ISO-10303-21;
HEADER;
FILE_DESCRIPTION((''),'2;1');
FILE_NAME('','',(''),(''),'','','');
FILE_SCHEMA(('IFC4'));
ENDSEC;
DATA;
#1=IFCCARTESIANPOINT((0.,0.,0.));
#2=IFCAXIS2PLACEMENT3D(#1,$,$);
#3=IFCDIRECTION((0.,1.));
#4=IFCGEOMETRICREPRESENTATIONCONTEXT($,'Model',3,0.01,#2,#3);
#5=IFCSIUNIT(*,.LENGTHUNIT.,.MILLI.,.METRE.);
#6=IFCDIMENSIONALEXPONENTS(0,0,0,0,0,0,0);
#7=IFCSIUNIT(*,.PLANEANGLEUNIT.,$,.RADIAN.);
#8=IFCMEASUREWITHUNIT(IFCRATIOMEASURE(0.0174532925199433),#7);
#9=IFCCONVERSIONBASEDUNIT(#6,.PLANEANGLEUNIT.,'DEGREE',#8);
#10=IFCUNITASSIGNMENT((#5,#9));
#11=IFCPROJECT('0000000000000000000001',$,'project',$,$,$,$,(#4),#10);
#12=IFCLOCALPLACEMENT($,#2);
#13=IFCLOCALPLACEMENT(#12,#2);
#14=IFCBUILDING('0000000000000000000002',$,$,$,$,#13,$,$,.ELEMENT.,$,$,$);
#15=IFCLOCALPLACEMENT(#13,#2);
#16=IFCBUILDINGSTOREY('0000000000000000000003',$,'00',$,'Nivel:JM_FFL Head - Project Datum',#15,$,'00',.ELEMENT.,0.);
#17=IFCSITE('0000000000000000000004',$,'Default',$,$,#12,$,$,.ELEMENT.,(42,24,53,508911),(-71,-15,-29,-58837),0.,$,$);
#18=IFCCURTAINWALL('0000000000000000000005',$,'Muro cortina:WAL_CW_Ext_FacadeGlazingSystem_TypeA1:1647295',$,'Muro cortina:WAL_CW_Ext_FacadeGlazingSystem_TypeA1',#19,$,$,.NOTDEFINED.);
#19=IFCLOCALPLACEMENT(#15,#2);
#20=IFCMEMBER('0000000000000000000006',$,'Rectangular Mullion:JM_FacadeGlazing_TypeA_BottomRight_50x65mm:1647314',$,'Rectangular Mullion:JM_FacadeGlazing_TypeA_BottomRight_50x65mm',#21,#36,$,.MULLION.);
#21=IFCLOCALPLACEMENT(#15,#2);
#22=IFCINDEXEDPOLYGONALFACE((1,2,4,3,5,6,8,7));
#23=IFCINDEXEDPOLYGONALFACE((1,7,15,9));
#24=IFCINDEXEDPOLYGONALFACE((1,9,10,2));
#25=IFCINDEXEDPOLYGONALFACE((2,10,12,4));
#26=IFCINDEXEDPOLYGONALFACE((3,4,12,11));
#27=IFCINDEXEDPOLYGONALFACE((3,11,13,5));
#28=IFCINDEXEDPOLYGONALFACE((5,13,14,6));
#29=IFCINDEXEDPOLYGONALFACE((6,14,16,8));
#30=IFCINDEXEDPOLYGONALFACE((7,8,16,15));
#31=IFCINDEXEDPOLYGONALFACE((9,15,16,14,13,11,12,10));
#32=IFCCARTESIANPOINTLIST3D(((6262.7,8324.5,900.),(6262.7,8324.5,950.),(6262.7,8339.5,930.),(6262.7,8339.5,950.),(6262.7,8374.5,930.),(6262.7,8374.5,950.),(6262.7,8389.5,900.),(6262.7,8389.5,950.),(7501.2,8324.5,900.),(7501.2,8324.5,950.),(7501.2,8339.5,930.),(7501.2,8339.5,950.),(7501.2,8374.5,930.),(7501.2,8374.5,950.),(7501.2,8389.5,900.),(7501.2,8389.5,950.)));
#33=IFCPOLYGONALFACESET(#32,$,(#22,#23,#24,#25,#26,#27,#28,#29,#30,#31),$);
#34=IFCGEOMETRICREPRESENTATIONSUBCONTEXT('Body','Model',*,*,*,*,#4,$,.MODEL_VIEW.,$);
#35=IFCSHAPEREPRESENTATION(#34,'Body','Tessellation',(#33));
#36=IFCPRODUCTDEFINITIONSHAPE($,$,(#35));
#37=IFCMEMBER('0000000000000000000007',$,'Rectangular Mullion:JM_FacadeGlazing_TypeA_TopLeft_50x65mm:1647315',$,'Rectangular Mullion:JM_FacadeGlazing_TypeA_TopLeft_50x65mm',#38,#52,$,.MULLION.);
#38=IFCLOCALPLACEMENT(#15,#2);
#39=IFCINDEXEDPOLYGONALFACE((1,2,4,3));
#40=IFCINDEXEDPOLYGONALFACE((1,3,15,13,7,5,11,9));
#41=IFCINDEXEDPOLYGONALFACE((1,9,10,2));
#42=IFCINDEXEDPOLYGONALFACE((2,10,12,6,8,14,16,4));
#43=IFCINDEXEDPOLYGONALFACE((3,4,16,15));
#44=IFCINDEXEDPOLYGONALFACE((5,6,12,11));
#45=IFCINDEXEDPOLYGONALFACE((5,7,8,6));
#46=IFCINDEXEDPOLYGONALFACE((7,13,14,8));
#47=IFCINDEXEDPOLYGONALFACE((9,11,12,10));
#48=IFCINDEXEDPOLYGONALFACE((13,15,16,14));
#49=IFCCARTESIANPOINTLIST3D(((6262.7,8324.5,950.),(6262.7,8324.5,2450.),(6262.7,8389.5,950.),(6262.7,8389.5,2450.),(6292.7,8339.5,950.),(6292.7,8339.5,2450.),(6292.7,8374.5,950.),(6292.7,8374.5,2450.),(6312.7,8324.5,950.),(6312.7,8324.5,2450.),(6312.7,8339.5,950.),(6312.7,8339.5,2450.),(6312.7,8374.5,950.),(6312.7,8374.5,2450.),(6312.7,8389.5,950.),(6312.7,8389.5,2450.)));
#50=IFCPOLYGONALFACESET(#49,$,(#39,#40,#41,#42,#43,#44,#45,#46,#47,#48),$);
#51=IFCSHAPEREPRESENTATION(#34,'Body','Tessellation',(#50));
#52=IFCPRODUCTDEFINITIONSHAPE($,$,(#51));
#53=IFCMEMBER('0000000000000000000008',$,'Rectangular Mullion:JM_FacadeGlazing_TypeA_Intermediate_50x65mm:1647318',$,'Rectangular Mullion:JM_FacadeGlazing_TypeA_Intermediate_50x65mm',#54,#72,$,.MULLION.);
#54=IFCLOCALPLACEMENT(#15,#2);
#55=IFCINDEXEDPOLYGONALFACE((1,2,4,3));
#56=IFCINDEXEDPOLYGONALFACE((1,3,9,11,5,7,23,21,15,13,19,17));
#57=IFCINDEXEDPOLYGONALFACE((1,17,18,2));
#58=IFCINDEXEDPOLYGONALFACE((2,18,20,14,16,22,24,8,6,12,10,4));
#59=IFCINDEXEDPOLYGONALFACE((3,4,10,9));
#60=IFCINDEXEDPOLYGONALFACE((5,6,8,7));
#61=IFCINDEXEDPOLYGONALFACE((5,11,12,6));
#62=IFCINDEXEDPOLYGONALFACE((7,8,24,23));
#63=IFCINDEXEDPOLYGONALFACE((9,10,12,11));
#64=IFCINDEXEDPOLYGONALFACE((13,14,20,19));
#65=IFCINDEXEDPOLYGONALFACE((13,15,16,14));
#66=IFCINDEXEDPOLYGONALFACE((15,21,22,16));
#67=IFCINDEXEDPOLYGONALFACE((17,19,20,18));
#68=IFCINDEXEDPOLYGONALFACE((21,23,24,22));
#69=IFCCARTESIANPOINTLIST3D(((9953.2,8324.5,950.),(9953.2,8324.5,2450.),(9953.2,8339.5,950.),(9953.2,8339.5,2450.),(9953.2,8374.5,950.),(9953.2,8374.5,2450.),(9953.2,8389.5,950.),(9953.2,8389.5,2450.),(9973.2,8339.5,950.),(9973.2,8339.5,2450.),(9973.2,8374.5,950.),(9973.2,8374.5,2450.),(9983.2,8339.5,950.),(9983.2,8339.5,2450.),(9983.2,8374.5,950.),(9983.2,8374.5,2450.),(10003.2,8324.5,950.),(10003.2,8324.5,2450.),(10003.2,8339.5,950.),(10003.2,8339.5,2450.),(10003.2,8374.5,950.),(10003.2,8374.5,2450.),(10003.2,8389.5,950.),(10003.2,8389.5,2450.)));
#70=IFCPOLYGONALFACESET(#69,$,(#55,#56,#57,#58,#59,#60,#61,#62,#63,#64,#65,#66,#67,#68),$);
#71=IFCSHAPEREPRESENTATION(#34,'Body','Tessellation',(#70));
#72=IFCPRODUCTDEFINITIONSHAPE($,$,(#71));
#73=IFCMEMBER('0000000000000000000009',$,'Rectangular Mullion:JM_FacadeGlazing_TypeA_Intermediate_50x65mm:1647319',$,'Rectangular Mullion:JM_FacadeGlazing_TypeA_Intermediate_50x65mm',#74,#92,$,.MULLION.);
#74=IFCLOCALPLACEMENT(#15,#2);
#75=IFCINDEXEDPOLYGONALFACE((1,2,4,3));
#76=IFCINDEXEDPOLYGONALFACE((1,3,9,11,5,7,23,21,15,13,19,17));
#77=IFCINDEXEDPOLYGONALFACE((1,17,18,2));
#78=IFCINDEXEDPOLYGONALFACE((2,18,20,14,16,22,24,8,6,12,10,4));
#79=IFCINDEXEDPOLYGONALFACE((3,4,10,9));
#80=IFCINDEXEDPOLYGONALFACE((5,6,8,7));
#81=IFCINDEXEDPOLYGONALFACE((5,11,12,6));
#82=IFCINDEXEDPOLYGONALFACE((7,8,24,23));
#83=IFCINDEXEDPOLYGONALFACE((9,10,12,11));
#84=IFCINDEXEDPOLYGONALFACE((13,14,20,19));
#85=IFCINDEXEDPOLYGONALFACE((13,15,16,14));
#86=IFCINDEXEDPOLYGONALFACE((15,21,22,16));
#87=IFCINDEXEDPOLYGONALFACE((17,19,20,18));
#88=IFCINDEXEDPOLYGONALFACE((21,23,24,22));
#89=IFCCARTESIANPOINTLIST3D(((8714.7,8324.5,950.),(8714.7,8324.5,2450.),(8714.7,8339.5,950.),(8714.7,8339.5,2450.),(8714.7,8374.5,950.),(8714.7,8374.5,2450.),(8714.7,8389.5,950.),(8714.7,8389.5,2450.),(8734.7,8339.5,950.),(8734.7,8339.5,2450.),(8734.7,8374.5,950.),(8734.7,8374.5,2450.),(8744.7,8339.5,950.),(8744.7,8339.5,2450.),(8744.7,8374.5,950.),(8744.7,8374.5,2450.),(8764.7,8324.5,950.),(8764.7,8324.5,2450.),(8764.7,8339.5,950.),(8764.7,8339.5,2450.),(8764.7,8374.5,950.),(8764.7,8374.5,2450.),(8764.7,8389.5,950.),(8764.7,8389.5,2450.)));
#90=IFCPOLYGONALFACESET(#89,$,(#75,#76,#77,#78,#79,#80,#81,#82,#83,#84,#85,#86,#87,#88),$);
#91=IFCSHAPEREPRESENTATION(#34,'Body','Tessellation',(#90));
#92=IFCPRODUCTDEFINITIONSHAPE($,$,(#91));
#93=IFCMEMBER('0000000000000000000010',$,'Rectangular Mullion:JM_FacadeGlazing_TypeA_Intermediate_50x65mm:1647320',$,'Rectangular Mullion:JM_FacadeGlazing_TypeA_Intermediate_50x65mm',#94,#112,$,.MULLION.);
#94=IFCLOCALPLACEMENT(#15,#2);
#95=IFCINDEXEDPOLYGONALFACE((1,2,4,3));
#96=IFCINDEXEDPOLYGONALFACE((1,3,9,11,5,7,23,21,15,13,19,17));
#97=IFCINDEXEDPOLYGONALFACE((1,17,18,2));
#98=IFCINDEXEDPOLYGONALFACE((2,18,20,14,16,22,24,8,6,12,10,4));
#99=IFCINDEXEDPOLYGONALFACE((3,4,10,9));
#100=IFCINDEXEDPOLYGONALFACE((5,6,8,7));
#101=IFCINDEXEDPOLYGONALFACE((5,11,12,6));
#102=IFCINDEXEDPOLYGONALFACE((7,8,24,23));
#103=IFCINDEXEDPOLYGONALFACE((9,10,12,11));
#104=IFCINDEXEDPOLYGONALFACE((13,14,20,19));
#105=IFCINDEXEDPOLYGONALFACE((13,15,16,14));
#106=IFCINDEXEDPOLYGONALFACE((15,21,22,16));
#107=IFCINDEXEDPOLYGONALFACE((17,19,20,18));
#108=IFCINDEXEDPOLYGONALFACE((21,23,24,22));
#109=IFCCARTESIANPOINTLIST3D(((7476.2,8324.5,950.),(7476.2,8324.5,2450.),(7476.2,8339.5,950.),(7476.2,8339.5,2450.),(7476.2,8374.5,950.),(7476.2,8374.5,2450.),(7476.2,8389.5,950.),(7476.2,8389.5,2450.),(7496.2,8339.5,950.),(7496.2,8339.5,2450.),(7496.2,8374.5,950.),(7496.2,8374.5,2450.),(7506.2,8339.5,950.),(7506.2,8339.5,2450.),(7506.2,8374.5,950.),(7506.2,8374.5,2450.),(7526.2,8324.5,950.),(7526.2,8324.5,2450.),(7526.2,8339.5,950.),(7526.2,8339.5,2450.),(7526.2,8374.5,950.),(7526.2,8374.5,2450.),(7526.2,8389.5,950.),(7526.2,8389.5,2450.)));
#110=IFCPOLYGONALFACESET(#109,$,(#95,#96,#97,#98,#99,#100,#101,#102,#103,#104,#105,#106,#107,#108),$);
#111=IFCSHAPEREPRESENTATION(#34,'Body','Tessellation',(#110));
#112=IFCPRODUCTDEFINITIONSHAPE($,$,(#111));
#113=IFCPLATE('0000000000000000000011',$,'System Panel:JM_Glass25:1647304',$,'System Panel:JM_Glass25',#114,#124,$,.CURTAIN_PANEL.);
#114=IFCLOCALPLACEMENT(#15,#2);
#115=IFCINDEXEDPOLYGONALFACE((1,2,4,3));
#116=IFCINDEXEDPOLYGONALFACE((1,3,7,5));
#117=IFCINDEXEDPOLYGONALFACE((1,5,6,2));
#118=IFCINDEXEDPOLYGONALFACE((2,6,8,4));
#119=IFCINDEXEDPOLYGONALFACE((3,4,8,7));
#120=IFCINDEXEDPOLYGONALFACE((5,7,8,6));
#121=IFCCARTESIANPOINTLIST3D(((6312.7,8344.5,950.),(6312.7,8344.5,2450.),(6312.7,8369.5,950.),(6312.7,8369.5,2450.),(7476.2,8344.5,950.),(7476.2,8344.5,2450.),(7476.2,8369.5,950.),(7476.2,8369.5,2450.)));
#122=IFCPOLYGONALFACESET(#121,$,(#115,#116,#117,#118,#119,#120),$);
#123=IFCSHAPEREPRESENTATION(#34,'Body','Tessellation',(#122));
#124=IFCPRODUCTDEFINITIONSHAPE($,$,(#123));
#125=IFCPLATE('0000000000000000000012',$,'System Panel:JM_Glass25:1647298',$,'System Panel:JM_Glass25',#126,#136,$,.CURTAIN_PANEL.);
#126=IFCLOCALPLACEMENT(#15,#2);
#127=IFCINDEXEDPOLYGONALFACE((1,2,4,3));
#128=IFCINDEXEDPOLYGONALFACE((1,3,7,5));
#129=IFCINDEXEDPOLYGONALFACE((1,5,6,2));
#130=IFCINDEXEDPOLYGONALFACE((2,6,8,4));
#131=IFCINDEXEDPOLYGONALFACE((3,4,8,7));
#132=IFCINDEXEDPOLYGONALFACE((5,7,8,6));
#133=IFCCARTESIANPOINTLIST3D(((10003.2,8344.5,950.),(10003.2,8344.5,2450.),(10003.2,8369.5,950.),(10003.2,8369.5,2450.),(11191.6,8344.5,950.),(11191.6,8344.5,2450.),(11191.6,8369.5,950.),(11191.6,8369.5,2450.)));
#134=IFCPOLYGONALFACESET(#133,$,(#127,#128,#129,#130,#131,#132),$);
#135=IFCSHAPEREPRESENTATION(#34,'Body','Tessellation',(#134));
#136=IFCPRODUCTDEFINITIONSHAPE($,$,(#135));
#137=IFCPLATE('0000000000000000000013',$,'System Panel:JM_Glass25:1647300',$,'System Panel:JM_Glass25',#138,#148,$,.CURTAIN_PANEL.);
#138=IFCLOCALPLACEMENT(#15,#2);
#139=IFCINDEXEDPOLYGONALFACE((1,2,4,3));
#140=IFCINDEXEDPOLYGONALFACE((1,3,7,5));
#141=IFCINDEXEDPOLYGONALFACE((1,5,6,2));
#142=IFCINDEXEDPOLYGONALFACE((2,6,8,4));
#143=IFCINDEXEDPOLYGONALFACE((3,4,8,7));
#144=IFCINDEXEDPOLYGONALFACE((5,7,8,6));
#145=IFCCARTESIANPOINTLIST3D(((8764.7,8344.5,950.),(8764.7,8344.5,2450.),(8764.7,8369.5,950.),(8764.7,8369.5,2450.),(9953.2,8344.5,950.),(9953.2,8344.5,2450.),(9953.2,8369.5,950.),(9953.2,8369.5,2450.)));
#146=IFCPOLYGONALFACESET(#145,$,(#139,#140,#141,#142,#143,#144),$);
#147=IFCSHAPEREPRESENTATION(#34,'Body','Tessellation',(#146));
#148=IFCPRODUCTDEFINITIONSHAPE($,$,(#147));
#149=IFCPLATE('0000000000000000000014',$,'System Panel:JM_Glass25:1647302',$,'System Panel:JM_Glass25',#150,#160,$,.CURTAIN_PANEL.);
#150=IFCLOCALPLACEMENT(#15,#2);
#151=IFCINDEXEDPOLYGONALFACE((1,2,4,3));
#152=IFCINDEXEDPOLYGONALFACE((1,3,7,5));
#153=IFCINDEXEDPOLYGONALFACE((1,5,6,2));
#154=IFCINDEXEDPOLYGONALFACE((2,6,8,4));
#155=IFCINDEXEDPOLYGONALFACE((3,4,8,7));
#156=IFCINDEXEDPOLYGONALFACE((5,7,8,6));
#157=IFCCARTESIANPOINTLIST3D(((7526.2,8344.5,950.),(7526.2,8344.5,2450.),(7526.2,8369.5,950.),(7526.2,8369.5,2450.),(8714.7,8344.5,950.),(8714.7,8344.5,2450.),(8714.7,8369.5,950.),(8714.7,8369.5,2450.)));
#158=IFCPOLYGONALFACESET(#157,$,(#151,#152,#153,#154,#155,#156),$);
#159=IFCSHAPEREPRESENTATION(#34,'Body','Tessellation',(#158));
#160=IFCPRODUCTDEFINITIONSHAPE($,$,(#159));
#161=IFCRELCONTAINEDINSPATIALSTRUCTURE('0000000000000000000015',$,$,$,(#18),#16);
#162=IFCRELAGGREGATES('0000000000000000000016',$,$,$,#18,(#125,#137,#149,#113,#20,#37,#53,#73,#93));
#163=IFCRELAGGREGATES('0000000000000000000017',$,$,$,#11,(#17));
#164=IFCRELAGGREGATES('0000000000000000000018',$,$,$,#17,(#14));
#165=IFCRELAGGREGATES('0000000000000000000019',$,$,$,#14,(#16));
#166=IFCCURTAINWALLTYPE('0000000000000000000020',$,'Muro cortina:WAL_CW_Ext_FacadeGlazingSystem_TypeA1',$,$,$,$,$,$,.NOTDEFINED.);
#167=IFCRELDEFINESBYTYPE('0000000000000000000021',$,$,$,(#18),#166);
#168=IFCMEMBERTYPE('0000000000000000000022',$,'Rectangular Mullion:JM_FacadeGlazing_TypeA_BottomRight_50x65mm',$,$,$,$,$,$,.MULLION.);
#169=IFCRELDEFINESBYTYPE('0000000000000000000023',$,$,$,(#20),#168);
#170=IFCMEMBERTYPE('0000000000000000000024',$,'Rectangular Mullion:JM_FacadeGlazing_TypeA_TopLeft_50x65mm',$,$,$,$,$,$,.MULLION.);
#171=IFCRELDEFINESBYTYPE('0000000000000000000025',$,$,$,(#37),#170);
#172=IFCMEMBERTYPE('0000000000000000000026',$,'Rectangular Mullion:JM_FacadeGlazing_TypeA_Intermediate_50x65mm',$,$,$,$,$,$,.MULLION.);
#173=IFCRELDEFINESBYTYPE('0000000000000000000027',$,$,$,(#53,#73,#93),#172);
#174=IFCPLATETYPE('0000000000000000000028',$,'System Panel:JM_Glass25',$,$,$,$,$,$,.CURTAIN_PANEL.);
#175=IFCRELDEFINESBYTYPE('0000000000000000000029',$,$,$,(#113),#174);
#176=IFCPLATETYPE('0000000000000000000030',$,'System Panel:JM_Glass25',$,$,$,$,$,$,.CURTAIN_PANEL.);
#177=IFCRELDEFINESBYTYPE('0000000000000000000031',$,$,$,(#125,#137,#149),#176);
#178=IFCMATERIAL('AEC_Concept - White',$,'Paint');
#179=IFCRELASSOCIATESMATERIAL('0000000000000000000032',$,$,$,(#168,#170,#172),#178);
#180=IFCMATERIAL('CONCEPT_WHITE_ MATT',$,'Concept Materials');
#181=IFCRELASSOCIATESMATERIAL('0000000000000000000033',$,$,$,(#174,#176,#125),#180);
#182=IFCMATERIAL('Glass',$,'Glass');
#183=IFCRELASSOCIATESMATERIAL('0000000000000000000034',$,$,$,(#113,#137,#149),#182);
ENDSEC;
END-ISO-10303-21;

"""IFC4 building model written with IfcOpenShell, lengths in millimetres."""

from ifc_helpers import new_model, entity, si_unit, converted_unit, direction, frame, origin, place, context, subcontext, project, spatial, indexed_curve, outline, extrude, source, transform, mapped, material, type_object, type_shapes, element, aggregate, save


model = new_model("IFC4")

# Units and contexts
model_context = context("Model", 3, precision=0.01, world=origin(), true_north=direction((0.0, 1.0)))
body_context = subcontext(model_context, "Body", "Model", "MODEL_VIEW")
ifc_project = project(units=[si_unit("LENGTHUNIT", "METRE", prefix="MILLI"), converted_unit("PLANEANGLEUNIT", "DEGREE", entity("IfcRatioMeasure", 0.0174532925199433), si_unit("PLANEANGLEUNIT", "RADIAN"), dimensions=[0, 0, 0, 0, 0, 0, 0])], contexts=[model_context])

# Site, building, storey
site_placement = place(None, origin())
site = spatial("IfcSite", under=ifc_project, at=site_placement, Name="Default", CompositionType="ELEMENT", RefLatitude=(42, 24, 53, 508911), RefLongitude=(-71, -15, -29, -58837), RefElevation=0.0)
building_placement = place(site_placement, origin())
building = spatial("IfcBuilding", under=site, at=building_placement, CompositionType="ELEMENT")
storey_placement = place(building_placement, origin())
storey = spatial("IfcBuildingStorey", under=building, at=storey_placement, Name="00", ObjectType="Nivel:JM_FFL Head - Project Datum", LongName="00", CompositionType="ELEMENT", Elevation=0.0)

# Shared definitions
curtain_wall_type = type_object("IfcCurtainWallType", Name="Muro cortina:WAL_CW_Ext_FacadeGlazingSystem_TypeA1", PredefinedType="NOTDEFINED")
ifc_material_1 = material(Name="AEC_Concept - White", Category="Paint")

# Curtain wall, members, plates
curtain_wall_1_placement = place(storey_placement, origin())
curtain_wall_1 = element("IfcCurtainWall", 1, at=curtain_wall_1_placement, inside=storey, type_object=curtain_wall_type, Name="Muro cortina:WAL_CW_Ext_FacadeGlazingSystem_TypeA1:1647295", ObjectType="Muro cortina:WAL_CW_Ext_FacadeGlazingSystem_TypeA1", PredefinedType="NOTDEFINED")
member_type_1 = type_object("IfcMemberType", Name="Rectangular Mullion:JM_FacadeGlazing_TypeA_BottomRight_50x65mm", PredefinedType="MULLION", material=ifc_material_1)
shared_shape_1 = source(origin(), body_context, "Body", "SweptSolid", [
    extrude(outline(indexed_curve([(-32.5, -17.5), (-17.5, -17.5), (-17.5, 2.5), (17.5, 2.5), (17.5, -17.5), (32.5, -17.5), (32.5, 32.5), (-32.5, 32.5), (-32.5, -17.5)], self_intersect=False)), frame((-32.5, -32.5, -1238.5), z_axis=(0.0, 0.0, 1.0), x_axis=(0.0, -1.0, 0.0)), (0.0, 0.0, 1.0), 1238.5),
])
type_shapes(member_type_1, [shared_shape_1])
member_1_placement = place(curtain_wall_1_placement, frame((7501.2, 8389.5, 900.0), z_axis=(1.0, 0.0, 0.0), x_axis=(0.0, 0.0, -1.0)))
member_1 = element("IfcMember", 2, at=member_1_placement, type_object=member_type_1, Name="Rectangular Mullion:JM_FacadeGlazing_TypeA_BottomRight_50x65mm:1647314", ObjectType="Rectangular Mullion:JM_FacadeGlazing_TypeA_BottomRight_50x65mm", PredefinedType="MULLION", context=body_context, shape_type="MappedRepresentation", body=[
    mapped(shared_shape_1, transform((0.0, 0.0, 0.0), scale=1.0)),
])
member_type_2 = type_object("IfcMemberType", Name="Rectangular Mullion:JM_FacadeGlazing_TypeA_TopLeft_50x65mm", PredefinedType="MULLION", material=ifc_material_1)
shared_shape_2 = source(origin(), body_context, "Body", "SweptSolid", [
    extrude(outline(indexed_curve([(-32.5, -17.5), (-17.5, -17.5), (-17.5, 2.5), (17.5, 2.5), (17.5, -17.5), (32.5, -17.5), (32.5, 32.5), (-32.5, 32.5), (-32.5, -17.5)], self_intersect=False)), frame((-32.5, -32.5, -1500.0), z_axis=(0.0, 0.0, 1.0), x_axis=(0.0, -1.0, 0.0)), (0.0, 0.0, 1.0), 1500.0),
])
type_shapes(member_type_2, [shared_shape_2])
member_2_placement = place(curtain_wall_1_placement, frame((6262.7, 8389.5, 950.0), z_axis=(0.0, 0.0, -1.0), x_axis=(-1.0, 0.0, 0.0)))
member_2 = element("IfcMember", 3, at=member_2_placement, type_object=member_type_2, Name="Rectangular Mullion:JM_FacadeGlazing_TypeA_TopLeft_50x65mm:1647315", ObjectType="Rectangular Mullion:JM_FacadeGlazing_TypeA_TopLeft_50x65mm", PredefinedType="MULLION", context=body_context, shape_type="MappedRepresentation", body=[
    mapped(shared_shape_2, transform((0.0, 0.0, 0.0), scale=1.0)),
])
member_type_3 = type_object("IfcMemberType", Name="Rectangular Mullion:JM_FacadeGlazing_TypeA_Intermediate_50x65mm", PredefinedType="MULLION", material=ifc_material_1)
shared_shape_3 = source(origin(), body_context, "Body", "SweptSolid", [
    extrude(outline(indexed_curve([(-32.5, -25.0), (-17.5, -25.0), (-17.5, -5.0), (17.5, -5.0), (17.5, -25.0), (32.5, -25.0), (32.5, 25.0), (17.5, 25.0), (17.5, 5.0), (-17.5, 5.0), (-17.5, 25.0), (-32.5, 25.0), (-32.5, -25.0)], self_intersect=False)), frame((0.0, -32.5, -1500.0), z_axis=(0.0, 0.0, 1.0), x_axis=(0.0, -1.0, 0.0)), (0.0, 0.0, 1.0), 1500.0),
])
type_shapes(member_type_3, [shared_shape_3])
member_3_placement = place(curtain_wall_1_placement, frame((9978.2, 8389.5, 950.0), z_axis=(0.0, 0.0, -1.0), x_axis=(-1.0, 0.0, 0.0)))
member_3 = element("IfcMember", 4, at=member_3_placement, type_object=member_type_3, Name="Rectangular Mullion:JM_FacadeGlazing_TypeA_Intermediate_50x65mm:1647318", ObjectType="Rectangular Mullion:JM_FacadeGlazing_TypeA_Intermediate_50x65mm", PredefinedType="MULLION", context=body_context, shape_type="MappedRepresentation", body=[
    mapped(shared_shape_3, transform((0.0, 0.0, 0.0), scale=1.0)),
])
member_4_placement = place(curtain_wall_1_placement, frame((8739.7, 8389.5, 950.0), z_axis=(0.0, 0.0, -1.0), x_axis=(-1.0, 0.0, 0.0)))
member_4 = element("IfcMember", 5, at=member_4_placement, type_object=member_type_3, Name="Rectangular Mullion:JM_FacadeGlazing_TypeA_Intermediate_50x65mm:1647319", ObjectType="Rectangular Mullion:JM_FacadeGlazing_TypeA_Intermediate_50x65mm", PredefinedType="MULLION", context=body_context, shape_type="MappedRepresentation", body=[
    mapped(shared_shape_3, transform((0.0, 0.0, 0.0), scale=1.0)),
])
member_5_placement = place(curtain_wall_1_placement, frame((7501.2, 8389.5, 950.0), z_axis=(0.0, 0.0, -1.0), x_axis=(-1.0, 0.0, 0.0)))
member_5 = element("IfcMember", 6, at=member_5_placement, type_object=member_type_3, Name="Rectangular Mullion:JM_FacadeGlazing_TypeA_Intermediate_50x65mm:1647320", ObjectType="Rectangular Mullion:JM_FacadeGlazing_TypeA_Intermediate_50x65mm", PredefinedType="MULLION", context=body_context, shape_type="MappedRepresentation", body=[
    mapped(shared_shape_3, transform((0.0, 0.0, 0.0), scale=1.0)),
])
ifc_material_2 = material(Name="Glass", Category="Glass")
ifc_material_3 = material(Name="CONCEPT_WHITE_ MATT", Category="Concept Materials")
plate_type_1 = type_object("IfcPlateType", Name="System Panel:JM_Glass25", PredefinedType="CURTAIN_PANEL", material=ifc_material_3)
shared_shape_4 = source(origin(), body_context, "Body", "SweptSolid", [
    extrude(outline(indexed_curve([(-12.5, -581.7), (12.5, -581.7), (12.5, 581.7), (-12.5, 581.7), (-12.5, -581.7)], self_intersect=False)), frame((0.0, 32.5, 0.0), z_axis=(0.0, 0.0, 1.0), x_axis=(0.0, 1.0, 0.0)), (0.0, 0.0, 1.0), 1500.0),
])
type_shapes(plate_type_1, [shared_shape_4])
plate_1_placement = place(curtain_wall_1_placement, frame((6894.5, 8389.5, 950.0), z_axis=(0.0, 0.0, 1.0), x_axis=(-1.0, 0.0, 0.0)))
plate_1 = element("IfcPlate", 7, at=plate_1_placement, type_object=plate_type_1, material=ifc_material_2, Name="System Panel:JM_Glass25:1647304", ObjectType="System Panel:JM_Glass25", PredefinedType="CURTAIN_PANEL", context=body_context, shape_type="MappedRepresentation", body=[
    mapped(shared_shape_4, transform((0.0, 0.0, 0.0), scale=1.0)),
])
plate_type_2 = type_object("IfcPlateType", Name="System Panel:JM_Glass25", PredefinedType="CURTAIN_PANEL", material=ifc_material_3)
shared_shape_5 = source(origin(), body_context, "Body", "SweptSolid", [
    extrude(outline(indexed_curve([(-12.5, -594.2), (12.5, -594.2), (12.5, 594.2), (-12.5, 594.2), (-12.5, -594.2)], self_intersect=False)), frame((0.0, 32.5, 0.0), z_axis=(0.0, 0.0, 1.0), x_axis=(0.0, 1.0, 0.0)), (0.0, 0.0, 1.0), 1500.0),
])
type_shapes(plate_type_2, [shared_shape_5])
plate_2_placement = place(curtain_wall_1_placement, frame((10597.4, 8389.5, 950.0), z_axis=(0.0, 0.0, 1.0), x_axis=(-1.0, 0.0, 0.0)))
plate_2 = element("IfcPlate", 8, at=plate_2_placement, type_object=plate_type_2, material=ifc_material_3, Name="System Panel:JM_Glass25:1647298", ObjectType="System Panel:JM_Glass25", PredefinedType="CURTAIN_PANEL", context=body_context, shape_type="MappedRepresentation", body=[
    mapped(shared_shape_5, transform((0.0, 0.0, 0.0), scale=1.0)),
])
plate_3_placement = place(curtain_wall_1_placement, frame((9358.9, 8389.5, 950.0), z_axis=(0.0, 0.0, 1.0), x_axis=(-1.0, 0.0, 0.0)))
plate_3 = element("IfcPlate", 9, at=plate_3_placement, type_object=plate_type_2, material=ifc_material_2, Name="System Panel:JM_Glass25:1647300", ObjectType="System Panel:JM_Glass25", PredefinedType="CURTAIN_PANEL", context=body_context, shape_type="MappedRepresentation", body=[
    mapped(shared_shape_5, transform((0.0, 0.0, 0.0), scale=1.0)),
])
plate_4_placement = place(curtain_wall_1_placement, frame((8120.4, 8389.5, 950.0), z_axis=(0.0, 0.0, 1.0), x_axis=(-1.0, 0.0, 0.0)))
plate_4 = element("IfcPlate", 10, at=plate_4_placement, type_object=plate_type_2, material=ifc_material_2, Name="System Panel:JM_Glass25:1647302", ObjectType="System Panel:JM_Glass25", PredefinedType="CURTAIN_PANEL", context=body_context, shape_type="MappedRepresentation", body=[
    mapped(shared_shape_5, transform((0.0, 0.0, 0.0), scale=1.0)),
])
aggregate(curtain_wall_1, [plate_2, plate_3, plate_4, plate_1, member_1, member_2, member_3, member_4, member_5])

save(model, "model.ifc")
